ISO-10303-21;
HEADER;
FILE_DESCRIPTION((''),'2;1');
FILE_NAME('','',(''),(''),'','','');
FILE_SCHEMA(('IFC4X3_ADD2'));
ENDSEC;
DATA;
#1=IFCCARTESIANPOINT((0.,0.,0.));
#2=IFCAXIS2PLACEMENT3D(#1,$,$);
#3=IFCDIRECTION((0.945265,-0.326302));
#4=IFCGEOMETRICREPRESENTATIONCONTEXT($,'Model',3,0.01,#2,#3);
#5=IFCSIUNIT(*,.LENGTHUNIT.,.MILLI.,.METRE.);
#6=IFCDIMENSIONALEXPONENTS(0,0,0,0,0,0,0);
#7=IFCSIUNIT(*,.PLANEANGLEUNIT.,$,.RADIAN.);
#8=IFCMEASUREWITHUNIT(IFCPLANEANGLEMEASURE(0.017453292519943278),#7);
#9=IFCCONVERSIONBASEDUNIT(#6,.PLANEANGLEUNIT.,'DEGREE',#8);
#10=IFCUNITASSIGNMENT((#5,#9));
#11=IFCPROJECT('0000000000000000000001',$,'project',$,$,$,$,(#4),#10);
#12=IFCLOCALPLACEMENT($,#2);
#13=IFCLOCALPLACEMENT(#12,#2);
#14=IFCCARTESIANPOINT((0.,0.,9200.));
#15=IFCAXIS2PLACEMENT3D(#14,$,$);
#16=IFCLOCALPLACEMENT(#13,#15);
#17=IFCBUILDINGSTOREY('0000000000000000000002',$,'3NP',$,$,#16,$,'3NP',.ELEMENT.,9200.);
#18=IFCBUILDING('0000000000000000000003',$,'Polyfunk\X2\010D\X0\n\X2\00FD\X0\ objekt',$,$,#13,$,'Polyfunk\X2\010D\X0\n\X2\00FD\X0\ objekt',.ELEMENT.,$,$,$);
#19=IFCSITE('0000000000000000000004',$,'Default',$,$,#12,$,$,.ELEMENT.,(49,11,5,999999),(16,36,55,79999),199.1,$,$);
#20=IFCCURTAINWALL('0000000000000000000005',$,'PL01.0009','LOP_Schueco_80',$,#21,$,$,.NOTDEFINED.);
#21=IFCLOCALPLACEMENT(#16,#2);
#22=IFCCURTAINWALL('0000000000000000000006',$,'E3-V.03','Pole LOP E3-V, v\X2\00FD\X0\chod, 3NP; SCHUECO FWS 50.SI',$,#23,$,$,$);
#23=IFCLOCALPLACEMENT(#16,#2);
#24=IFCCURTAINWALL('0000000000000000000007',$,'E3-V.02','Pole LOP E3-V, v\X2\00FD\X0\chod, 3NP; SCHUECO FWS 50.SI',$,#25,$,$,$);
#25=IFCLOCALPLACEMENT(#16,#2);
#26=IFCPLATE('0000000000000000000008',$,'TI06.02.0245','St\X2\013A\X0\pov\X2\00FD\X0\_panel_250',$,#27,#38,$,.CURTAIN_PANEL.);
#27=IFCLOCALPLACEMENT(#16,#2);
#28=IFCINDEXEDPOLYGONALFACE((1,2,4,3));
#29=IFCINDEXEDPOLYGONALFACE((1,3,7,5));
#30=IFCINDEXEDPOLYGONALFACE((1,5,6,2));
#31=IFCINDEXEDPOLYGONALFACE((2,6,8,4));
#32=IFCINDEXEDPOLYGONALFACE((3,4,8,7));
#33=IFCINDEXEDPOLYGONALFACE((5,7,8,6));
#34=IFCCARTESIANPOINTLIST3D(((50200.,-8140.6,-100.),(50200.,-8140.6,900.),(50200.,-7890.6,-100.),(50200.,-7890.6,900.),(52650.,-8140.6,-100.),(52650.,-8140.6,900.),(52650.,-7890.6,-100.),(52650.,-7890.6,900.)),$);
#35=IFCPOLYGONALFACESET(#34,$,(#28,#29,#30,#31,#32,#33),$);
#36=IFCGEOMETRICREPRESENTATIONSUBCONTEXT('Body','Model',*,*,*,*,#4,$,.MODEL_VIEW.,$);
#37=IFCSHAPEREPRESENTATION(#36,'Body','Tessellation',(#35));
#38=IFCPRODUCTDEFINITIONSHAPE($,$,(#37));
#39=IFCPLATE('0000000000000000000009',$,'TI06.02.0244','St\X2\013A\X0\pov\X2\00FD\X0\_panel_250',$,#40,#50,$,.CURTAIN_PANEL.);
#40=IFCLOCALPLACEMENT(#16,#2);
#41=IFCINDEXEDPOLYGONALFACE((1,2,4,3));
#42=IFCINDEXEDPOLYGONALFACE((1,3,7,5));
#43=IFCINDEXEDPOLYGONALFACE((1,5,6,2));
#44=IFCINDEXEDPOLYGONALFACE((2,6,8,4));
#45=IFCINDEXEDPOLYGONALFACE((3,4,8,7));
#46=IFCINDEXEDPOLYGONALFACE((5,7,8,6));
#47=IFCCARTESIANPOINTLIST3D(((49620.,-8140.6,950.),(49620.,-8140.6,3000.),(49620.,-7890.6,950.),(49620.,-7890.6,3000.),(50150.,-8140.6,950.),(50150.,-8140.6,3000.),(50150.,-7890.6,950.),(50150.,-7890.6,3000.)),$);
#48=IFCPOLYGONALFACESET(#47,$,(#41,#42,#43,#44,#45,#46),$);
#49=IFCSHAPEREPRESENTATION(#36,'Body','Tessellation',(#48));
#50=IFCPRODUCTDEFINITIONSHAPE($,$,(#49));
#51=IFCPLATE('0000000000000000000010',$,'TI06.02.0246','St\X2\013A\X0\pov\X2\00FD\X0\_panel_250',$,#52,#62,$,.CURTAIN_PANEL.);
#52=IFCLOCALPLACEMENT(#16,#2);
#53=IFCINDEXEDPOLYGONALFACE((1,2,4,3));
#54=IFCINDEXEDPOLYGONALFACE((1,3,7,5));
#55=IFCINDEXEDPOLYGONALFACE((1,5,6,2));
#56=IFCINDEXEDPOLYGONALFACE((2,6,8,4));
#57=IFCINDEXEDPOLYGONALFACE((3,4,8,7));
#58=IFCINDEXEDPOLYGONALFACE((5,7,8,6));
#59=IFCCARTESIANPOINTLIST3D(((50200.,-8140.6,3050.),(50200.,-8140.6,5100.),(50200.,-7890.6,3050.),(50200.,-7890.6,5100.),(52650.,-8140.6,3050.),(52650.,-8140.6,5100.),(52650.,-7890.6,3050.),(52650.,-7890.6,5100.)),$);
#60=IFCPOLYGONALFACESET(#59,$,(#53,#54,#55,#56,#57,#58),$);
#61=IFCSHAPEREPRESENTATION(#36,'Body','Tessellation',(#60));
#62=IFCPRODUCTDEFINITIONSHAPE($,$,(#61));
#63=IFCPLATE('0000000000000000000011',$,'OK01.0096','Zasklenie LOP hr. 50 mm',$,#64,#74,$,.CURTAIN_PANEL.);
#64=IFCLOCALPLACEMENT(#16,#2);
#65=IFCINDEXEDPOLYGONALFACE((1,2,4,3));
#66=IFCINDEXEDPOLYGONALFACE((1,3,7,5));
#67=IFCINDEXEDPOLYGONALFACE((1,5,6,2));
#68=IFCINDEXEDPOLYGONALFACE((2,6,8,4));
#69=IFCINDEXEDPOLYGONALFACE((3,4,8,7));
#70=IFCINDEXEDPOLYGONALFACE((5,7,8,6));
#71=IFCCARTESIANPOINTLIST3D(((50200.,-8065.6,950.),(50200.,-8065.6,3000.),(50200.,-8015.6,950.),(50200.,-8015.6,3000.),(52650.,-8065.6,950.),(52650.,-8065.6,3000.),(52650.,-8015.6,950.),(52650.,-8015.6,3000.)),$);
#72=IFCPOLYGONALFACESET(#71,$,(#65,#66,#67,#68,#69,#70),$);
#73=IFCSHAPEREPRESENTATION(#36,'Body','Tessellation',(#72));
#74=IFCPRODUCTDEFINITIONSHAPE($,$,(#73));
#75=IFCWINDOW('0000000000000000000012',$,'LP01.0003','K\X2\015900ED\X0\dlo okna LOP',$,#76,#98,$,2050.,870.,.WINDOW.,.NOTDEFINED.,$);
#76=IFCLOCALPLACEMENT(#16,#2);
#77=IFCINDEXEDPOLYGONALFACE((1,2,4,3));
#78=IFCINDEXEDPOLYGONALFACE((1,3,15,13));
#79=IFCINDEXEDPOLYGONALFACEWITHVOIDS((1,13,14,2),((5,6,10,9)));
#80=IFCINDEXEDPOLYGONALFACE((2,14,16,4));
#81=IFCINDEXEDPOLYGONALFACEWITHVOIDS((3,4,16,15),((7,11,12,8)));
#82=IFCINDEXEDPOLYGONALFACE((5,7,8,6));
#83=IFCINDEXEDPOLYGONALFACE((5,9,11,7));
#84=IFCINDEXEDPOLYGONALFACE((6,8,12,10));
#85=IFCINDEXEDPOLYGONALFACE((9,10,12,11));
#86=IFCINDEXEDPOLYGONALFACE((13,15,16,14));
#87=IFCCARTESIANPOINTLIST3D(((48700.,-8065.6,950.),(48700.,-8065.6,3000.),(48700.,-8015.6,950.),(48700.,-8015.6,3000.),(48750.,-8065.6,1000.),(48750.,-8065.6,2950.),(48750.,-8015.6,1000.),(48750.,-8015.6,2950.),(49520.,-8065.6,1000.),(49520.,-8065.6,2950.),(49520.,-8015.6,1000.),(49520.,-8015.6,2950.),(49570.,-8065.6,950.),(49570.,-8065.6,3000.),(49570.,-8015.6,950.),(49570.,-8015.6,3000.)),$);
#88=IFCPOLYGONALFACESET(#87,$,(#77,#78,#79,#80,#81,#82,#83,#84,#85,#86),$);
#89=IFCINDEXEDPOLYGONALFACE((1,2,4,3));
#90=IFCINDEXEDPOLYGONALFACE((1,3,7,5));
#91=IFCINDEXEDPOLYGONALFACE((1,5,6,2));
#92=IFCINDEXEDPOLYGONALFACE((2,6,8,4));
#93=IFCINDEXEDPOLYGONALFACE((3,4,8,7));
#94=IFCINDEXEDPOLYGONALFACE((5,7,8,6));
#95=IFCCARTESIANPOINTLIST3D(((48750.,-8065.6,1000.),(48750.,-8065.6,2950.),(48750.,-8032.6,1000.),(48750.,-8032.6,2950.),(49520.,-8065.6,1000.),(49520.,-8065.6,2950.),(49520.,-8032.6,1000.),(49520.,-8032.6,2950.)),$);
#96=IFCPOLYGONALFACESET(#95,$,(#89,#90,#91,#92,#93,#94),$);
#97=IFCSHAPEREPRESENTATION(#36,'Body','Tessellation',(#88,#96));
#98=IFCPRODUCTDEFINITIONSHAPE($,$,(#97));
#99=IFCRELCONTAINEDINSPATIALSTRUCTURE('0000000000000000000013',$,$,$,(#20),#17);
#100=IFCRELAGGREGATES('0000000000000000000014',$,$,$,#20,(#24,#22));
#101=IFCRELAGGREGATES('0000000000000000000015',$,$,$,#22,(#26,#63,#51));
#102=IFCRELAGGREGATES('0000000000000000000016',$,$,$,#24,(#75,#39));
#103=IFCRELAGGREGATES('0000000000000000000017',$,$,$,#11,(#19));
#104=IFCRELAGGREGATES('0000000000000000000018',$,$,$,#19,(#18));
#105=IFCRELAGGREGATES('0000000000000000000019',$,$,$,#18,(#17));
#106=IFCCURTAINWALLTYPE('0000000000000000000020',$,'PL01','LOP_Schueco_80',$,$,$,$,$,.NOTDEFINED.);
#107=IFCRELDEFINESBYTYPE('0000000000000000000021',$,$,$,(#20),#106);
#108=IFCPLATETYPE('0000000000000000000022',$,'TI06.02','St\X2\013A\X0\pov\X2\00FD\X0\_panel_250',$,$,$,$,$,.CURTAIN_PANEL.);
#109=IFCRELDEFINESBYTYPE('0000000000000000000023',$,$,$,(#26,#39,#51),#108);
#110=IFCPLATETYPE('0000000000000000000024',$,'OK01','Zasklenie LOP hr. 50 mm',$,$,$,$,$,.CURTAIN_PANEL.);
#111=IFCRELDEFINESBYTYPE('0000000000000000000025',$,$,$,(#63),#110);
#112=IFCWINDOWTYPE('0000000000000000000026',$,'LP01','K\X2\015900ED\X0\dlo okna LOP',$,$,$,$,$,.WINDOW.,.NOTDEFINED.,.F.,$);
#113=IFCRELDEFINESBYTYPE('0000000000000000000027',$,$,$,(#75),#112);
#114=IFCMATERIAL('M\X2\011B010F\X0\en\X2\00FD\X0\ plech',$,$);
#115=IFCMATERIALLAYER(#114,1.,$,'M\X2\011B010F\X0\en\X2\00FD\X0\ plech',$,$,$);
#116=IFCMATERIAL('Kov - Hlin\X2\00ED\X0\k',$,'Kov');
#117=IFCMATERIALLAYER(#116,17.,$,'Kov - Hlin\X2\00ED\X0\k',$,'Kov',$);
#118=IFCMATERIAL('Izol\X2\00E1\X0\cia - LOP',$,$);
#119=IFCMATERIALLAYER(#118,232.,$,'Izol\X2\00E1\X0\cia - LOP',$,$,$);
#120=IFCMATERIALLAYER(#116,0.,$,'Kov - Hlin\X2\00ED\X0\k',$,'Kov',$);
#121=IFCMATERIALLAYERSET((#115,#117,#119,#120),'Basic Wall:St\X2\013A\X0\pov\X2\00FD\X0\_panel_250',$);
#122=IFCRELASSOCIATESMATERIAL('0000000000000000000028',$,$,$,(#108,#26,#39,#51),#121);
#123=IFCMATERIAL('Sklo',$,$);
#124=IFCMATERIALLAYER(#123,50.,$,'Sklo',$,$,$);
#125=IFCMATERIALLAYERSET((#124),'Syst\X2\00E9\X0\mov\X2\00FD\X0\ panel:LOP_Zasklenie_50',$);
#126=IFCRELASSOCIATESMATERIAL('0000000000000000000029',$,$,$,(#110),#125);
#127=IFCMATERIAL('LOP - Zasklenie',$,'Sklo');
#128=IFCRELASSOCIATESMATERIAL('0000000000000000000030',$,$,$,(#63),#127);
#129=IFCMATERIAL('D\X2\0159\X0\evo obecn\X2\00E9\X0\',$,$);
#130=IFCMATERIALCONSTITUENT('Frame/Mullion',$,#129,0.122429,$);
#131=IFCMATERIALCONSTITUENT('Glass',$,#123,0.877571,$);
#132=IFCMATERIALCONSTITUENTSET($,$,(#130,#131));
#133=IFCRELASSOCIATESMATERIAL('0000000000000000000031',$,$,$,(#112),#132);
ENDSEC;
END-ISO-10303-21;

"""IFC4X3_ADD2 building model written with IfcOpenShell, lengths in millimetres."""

from ifc_helpers import new_model, entity, si_unit, converted_unit, direction, frame, frame_2d, origin, origin_2d_with_axis, place, context, subcontext, project, spatial, polyline, rectangle, outline, extrude, source, transform, mapped, material, layer, layer_set, layer_usage, constituent, constituent_set, type_object, type_shapes, element, aggregate, save


model = new_model("IFC4X3_ADD2")

# Units and contexts
model_context = context("Model", 3, precision=0.01, world=origin(), true_north=direction((0.945265, -0.326302)))
body_context = subcontext(model_context, "Body", "Model", "MODEL_VIEW")
ifc_project = project(units=[si_unit("LENGTHUNIT", "METRE", prefix="MILLI"), converted_unit("PLANEANGLEUNIT", "DEGREE", entity("IfcPlaneAngleMeasure", 0.017453292519943278), si_unit("PLANEANGLEUNIT", "RADIAN"), dimensions=[0, 0, 0, 0, 0, 0, 0])], contexts=[model_context])

# Site, building, storey
site_placement = place(None, origin())
site = spatial("IfcSite", under=ifc_project, at=site_placement, Name="Default", CompositionType="ELEMENT", RefLatitude=(49, 11, 5, 999999), RefLongitude=(16, 36, 55, 79999), RefElevation=199.1)
building_placement = place(site_placement, origin())
building = spatial("IfcBuilding", under=site, at=building_placement, Name="Polyfunkčný objekt", LongName="Polyfunkčný objekt", CompositionType="ELEMENT")
storey_placement = place(building_placement, frame((0.0, 0.0, 9200.0)))
storey = spatial("IfcBuildingStorey", under=building, at=storey_placement, Name="3NP", LongName="3NP", CompositionType="ELEMENT", Elevation=9200.0)

# Curtain walls, plates, window
curtain_wall_type = type_object("IfcCurtainWallType", Name="PL01", Description="LOP_Schueco_80", PredefinedType="NOTDEFINED")
curtain_wall_1_placement = place(storey_placement, frame((0.0, 0.0, -9200.0)))
curtain_wall_1 = element("IfcCurtainWall", 1, at=curtain_wall_1_placement, inside=storey, type_object=curtain_wall_type, Name="PL01.0009", Description="LOP_Schueco_80", PredefinedType="NOTDEFINED")
curtain_wall_2 = element("IfcCurtainWall", 2, Name="E3-V.03", Description="Pole LOP E3-V, východ, 3NP; SCHUECO FWS 50.SI")
curtain_wall_3 = element("IfcCurtainWall", 3, Name="E3-V.02", Description="Pole LOP E3-V, východ, 3NP; SCHUECO FWS 50.SI")
aggregate(curtain_wall_1, [curtain_wall_3, curtain_wall_2])
ifc_material_1 = material(Name="Měďený plech")
ifc_layer_1 = layer(ifc_material_1, 1.0, Name="Měďený plech")
ifc_material_2 = material(Name="Kov - Hliník", Category="Kov")
ifc_layer_2 = layer(ifc_material_2, 17.0, Name="Kov - Hliník", Category="Kov")
ifc_material_3 = material(Name="Izolácia - LOP")
ifc_layer_3 = layer(ifc_material_3, 232.0, Name="Izolácia - LOP")
ifc_layer_4 = layer(ifc_material_2, 0.0, Name="Kov - Hliník", Category="Kov")
ifc_layer_set_1 = layer_set([ifc_layer_1, ifc_layer_2, ifc_layer_3, ifc_layer_4], Name="Basic Wall:Stĺpový_panel_250")
ifc_layer_usage_1 = layer_usage(ifc_layer_set_1, "AXIS2", "POSITIVE", -125.0)
plate_type_1 = type_object("IfcPlateType", Name="TI06.02", Description="Stĺpový_panel_250", PredefinedType="CURTAIN_PANEL", material=ifc_layer_set_1)
plate_1_placement = place(storey_placement, frame((50200.0, -8015.6, -100.0)))
plate_1 = element("IfcPlate", 4, at=plate_1_placement, type_object=plate_type_1, material=ifc_layer_usage_1, Name="TI06.02.0245", Description="Stĺpový_panel_250", PredefinedType="CURTAIN_PANEL", context=body_context, shape_type="SweptSolid", body=[
    extrude(rectangle(XDim=250.0, YDim=2450.0, at=origin_2d_with_axis()), frame((1225.0, 0.0, 0.0), z_axis=(0.0, 0.0, 1.0), x_axis=(0.0, 1.0, 0.0)), (0.0, 0.0, 1.0), 1000.0),
])
ifc_layer_usage_2 = layer_usage(ifc_layer_set_1, "AXIS2", "POSITIVE", -125.0)
plate_2_placement = place(storey_placement, frame((49620.0, -8015.6, 950.0)))
plate_2 = element("IfcPlate", 5, at=plate_2_placement, type_object=plate_type_1, material=ifc_layer_usage_2, Name="TI06.02.0244", Description="Stĺpový_panel_250", PredefinedType="CURTAIN_PANEL", context=body_context, shape_type="SweptSolid", body=[
    extrude(rectangle(XDim=250.0, YDim=530.0, at=origin_2d_with_axis()), frame((265.0, 0.0, 0.0), z_axis=(0.0, 0.0, 1.0), x_axis=(0.0, 1.0, 0.0)), (0.0, 0.0, 1.0), 2050.0),
])
ifc_layer_usage_3 = layer_usage(ifc_layer_set_1, "AXIS2", "POSITIVE", -125.0)
plate_3_placement = place(storey_placement, frame((50200.0, -8015.6, 3050.0)))
plate_3 = element("IfcPlate", 6, at=plate_3_placement, type_object=plate_type_1, material=ifc_layer_usage_3, Name="TI06.02.0246", Description="Stĺpový_panel_250", PredefinedType="CURTAIN_PANEL", context=body_context, shape_type="SweptSolid", body=[
    extrude(rectangle(XDim=250.0, YDim=2450.0, at=origin_2d_with_axis()), frame((1225.0, 0.0, 0.0), z_axis=(0.0, 0.0, 1.0), x_axis=(0.0, 1.0, 0.0)), (0.0, 0.0, 1.0), 2050.0),
])
ifc_material_4 = material(Name="LOP - Zasklenie", Category="Sklo")
ifc_material_5 = material(Name="Sklo")
ifc_layer_5 = layer(ifc_material_5, 50.0, Name="Sklo")
ifc_layer_set_2 = layer_set([ifc_layer_5], Name="Systémový panel:LOP_Zasklenie_50")
plate_type_2 = type_object("IfcPlateType", Name="OK01", Description="Zasklenie LOP hr. 50 mm", PredefinedType="CURTAIN_PANEL", material=ifc_layer_set_2)
shared_shape_1 = source(origin(), body_context, "Body", "SweptSolid", [
    extrude(rectangle(XDim=50.0, YDim=2450.0, at=origin_2d_with_axis()), frame((0.0, -25.0, 0.0), z_axis=(0.0, 0.0, 1.0), x_axis=(0.0, 1.0, 0.0)), (0.0, 0.0, 1.0), 2050.0),
])
type_shapes(plate_type_2, [shared_shape_1])
plate_4_placement = place(curtain_wall_1_placement, frame((51425.0, -8015.6, 10150.0)))
plate_4 = element("IfcPlate", 7, at=plate_4_placement, type_object=plate_type_2, material=ifc_material_4, Name="OK01.0096", Description="Zasklenie LOP hr. 50 mm", PredefinedType="CURTAIN_PANEL", context=body_context, shape_type="MappedRepresentation", body=[
    mapped(shared_shape_1, transform((0.0, 0.0, 0.0), scale=1.0)),
])
aggregate(curtain_wall_2, [plate_1, plate_4, plate_3])
ifc_material_6 = material(Name="Dřevo obecné")
ifc_constituent_1 = constituent(ifc_material_6, Name="Frame/Mullion", fraction=0.122429)
ifc_constituent_2 = constituent(ifc_material_5, Name="Glass", fraction=0.877571)
ifc_constituent_set = constituent_set(constituents=[ifc_constituent_1, ifc_constituent_2])
window_type = type_object("IfcWindowType", Name="LP01", Description="Křídlo okna LOP", ParameterTakesPrecedence=False, PartitioningType="NOTDEFINED", PredefinedType="WINDOW", material=ifc_constituent_set)
shared_shape_2 = source(origin(), body_context, "Body", "SweptSolid", [
    extrude(outline(polyline([(-1025.0, -435.0), (1025.0, -435.0), (1025.0, 435.0), (-1025.0, 435.0), (-1025.0, -435.0)]), holes=[polyline([(-975.0, -385.0), (-975.0, 385.0), (975.0, 385.0), (975.0, -385.0), (-975.0, -385.0)])]), frame((0.0, 50.0, 1025.0), z_axis=(0.0, -1.0, 0.0), x_axis=(0.0, 0.0, -1.0)), (0.0, 0.0, 1.0), 50.0),
    extrude(rectangle(XDim=770.0, YDim=33.0, at=frame_2d((0.0, 0.0), x_axis=(1.0, 0.0))), frame((0.0, 33.5, 50.0), z_axis=(0.0, 0.0, 1.0), x_axis=(-1.0, 0.0, 0.0)), (0.0, 0.0, 1.0), 1950.0),
])
type_shapes(window_type, [shared_shape_2])
window_placement = place(curtain_wall_1_placement, frame((49135.0, -8015.6, 10150.0), z_axis=(0.0, 0.0, 1.0), x_axis=(-1.0, 0.0, 0.0)))
window = element("IfcWindow", 8, at=window_placement, type_object=window_type, Name="LP01.0003", Description="Křídlo okna LOP", OverallHeight=2050.0, OverallWidth=870.0, PartitioningType="NOTDEFINED", PredefinedType="WINDOW", context=body_context, shape_type="MappedRepresentation", body=[
    mapped(shared_shape_2, transform((0.0, 0.0, 0.0), scale=1.0)),
])
aggregate(curtain_wall_3, [window, plate_2])

save(model, "model.ifc")
